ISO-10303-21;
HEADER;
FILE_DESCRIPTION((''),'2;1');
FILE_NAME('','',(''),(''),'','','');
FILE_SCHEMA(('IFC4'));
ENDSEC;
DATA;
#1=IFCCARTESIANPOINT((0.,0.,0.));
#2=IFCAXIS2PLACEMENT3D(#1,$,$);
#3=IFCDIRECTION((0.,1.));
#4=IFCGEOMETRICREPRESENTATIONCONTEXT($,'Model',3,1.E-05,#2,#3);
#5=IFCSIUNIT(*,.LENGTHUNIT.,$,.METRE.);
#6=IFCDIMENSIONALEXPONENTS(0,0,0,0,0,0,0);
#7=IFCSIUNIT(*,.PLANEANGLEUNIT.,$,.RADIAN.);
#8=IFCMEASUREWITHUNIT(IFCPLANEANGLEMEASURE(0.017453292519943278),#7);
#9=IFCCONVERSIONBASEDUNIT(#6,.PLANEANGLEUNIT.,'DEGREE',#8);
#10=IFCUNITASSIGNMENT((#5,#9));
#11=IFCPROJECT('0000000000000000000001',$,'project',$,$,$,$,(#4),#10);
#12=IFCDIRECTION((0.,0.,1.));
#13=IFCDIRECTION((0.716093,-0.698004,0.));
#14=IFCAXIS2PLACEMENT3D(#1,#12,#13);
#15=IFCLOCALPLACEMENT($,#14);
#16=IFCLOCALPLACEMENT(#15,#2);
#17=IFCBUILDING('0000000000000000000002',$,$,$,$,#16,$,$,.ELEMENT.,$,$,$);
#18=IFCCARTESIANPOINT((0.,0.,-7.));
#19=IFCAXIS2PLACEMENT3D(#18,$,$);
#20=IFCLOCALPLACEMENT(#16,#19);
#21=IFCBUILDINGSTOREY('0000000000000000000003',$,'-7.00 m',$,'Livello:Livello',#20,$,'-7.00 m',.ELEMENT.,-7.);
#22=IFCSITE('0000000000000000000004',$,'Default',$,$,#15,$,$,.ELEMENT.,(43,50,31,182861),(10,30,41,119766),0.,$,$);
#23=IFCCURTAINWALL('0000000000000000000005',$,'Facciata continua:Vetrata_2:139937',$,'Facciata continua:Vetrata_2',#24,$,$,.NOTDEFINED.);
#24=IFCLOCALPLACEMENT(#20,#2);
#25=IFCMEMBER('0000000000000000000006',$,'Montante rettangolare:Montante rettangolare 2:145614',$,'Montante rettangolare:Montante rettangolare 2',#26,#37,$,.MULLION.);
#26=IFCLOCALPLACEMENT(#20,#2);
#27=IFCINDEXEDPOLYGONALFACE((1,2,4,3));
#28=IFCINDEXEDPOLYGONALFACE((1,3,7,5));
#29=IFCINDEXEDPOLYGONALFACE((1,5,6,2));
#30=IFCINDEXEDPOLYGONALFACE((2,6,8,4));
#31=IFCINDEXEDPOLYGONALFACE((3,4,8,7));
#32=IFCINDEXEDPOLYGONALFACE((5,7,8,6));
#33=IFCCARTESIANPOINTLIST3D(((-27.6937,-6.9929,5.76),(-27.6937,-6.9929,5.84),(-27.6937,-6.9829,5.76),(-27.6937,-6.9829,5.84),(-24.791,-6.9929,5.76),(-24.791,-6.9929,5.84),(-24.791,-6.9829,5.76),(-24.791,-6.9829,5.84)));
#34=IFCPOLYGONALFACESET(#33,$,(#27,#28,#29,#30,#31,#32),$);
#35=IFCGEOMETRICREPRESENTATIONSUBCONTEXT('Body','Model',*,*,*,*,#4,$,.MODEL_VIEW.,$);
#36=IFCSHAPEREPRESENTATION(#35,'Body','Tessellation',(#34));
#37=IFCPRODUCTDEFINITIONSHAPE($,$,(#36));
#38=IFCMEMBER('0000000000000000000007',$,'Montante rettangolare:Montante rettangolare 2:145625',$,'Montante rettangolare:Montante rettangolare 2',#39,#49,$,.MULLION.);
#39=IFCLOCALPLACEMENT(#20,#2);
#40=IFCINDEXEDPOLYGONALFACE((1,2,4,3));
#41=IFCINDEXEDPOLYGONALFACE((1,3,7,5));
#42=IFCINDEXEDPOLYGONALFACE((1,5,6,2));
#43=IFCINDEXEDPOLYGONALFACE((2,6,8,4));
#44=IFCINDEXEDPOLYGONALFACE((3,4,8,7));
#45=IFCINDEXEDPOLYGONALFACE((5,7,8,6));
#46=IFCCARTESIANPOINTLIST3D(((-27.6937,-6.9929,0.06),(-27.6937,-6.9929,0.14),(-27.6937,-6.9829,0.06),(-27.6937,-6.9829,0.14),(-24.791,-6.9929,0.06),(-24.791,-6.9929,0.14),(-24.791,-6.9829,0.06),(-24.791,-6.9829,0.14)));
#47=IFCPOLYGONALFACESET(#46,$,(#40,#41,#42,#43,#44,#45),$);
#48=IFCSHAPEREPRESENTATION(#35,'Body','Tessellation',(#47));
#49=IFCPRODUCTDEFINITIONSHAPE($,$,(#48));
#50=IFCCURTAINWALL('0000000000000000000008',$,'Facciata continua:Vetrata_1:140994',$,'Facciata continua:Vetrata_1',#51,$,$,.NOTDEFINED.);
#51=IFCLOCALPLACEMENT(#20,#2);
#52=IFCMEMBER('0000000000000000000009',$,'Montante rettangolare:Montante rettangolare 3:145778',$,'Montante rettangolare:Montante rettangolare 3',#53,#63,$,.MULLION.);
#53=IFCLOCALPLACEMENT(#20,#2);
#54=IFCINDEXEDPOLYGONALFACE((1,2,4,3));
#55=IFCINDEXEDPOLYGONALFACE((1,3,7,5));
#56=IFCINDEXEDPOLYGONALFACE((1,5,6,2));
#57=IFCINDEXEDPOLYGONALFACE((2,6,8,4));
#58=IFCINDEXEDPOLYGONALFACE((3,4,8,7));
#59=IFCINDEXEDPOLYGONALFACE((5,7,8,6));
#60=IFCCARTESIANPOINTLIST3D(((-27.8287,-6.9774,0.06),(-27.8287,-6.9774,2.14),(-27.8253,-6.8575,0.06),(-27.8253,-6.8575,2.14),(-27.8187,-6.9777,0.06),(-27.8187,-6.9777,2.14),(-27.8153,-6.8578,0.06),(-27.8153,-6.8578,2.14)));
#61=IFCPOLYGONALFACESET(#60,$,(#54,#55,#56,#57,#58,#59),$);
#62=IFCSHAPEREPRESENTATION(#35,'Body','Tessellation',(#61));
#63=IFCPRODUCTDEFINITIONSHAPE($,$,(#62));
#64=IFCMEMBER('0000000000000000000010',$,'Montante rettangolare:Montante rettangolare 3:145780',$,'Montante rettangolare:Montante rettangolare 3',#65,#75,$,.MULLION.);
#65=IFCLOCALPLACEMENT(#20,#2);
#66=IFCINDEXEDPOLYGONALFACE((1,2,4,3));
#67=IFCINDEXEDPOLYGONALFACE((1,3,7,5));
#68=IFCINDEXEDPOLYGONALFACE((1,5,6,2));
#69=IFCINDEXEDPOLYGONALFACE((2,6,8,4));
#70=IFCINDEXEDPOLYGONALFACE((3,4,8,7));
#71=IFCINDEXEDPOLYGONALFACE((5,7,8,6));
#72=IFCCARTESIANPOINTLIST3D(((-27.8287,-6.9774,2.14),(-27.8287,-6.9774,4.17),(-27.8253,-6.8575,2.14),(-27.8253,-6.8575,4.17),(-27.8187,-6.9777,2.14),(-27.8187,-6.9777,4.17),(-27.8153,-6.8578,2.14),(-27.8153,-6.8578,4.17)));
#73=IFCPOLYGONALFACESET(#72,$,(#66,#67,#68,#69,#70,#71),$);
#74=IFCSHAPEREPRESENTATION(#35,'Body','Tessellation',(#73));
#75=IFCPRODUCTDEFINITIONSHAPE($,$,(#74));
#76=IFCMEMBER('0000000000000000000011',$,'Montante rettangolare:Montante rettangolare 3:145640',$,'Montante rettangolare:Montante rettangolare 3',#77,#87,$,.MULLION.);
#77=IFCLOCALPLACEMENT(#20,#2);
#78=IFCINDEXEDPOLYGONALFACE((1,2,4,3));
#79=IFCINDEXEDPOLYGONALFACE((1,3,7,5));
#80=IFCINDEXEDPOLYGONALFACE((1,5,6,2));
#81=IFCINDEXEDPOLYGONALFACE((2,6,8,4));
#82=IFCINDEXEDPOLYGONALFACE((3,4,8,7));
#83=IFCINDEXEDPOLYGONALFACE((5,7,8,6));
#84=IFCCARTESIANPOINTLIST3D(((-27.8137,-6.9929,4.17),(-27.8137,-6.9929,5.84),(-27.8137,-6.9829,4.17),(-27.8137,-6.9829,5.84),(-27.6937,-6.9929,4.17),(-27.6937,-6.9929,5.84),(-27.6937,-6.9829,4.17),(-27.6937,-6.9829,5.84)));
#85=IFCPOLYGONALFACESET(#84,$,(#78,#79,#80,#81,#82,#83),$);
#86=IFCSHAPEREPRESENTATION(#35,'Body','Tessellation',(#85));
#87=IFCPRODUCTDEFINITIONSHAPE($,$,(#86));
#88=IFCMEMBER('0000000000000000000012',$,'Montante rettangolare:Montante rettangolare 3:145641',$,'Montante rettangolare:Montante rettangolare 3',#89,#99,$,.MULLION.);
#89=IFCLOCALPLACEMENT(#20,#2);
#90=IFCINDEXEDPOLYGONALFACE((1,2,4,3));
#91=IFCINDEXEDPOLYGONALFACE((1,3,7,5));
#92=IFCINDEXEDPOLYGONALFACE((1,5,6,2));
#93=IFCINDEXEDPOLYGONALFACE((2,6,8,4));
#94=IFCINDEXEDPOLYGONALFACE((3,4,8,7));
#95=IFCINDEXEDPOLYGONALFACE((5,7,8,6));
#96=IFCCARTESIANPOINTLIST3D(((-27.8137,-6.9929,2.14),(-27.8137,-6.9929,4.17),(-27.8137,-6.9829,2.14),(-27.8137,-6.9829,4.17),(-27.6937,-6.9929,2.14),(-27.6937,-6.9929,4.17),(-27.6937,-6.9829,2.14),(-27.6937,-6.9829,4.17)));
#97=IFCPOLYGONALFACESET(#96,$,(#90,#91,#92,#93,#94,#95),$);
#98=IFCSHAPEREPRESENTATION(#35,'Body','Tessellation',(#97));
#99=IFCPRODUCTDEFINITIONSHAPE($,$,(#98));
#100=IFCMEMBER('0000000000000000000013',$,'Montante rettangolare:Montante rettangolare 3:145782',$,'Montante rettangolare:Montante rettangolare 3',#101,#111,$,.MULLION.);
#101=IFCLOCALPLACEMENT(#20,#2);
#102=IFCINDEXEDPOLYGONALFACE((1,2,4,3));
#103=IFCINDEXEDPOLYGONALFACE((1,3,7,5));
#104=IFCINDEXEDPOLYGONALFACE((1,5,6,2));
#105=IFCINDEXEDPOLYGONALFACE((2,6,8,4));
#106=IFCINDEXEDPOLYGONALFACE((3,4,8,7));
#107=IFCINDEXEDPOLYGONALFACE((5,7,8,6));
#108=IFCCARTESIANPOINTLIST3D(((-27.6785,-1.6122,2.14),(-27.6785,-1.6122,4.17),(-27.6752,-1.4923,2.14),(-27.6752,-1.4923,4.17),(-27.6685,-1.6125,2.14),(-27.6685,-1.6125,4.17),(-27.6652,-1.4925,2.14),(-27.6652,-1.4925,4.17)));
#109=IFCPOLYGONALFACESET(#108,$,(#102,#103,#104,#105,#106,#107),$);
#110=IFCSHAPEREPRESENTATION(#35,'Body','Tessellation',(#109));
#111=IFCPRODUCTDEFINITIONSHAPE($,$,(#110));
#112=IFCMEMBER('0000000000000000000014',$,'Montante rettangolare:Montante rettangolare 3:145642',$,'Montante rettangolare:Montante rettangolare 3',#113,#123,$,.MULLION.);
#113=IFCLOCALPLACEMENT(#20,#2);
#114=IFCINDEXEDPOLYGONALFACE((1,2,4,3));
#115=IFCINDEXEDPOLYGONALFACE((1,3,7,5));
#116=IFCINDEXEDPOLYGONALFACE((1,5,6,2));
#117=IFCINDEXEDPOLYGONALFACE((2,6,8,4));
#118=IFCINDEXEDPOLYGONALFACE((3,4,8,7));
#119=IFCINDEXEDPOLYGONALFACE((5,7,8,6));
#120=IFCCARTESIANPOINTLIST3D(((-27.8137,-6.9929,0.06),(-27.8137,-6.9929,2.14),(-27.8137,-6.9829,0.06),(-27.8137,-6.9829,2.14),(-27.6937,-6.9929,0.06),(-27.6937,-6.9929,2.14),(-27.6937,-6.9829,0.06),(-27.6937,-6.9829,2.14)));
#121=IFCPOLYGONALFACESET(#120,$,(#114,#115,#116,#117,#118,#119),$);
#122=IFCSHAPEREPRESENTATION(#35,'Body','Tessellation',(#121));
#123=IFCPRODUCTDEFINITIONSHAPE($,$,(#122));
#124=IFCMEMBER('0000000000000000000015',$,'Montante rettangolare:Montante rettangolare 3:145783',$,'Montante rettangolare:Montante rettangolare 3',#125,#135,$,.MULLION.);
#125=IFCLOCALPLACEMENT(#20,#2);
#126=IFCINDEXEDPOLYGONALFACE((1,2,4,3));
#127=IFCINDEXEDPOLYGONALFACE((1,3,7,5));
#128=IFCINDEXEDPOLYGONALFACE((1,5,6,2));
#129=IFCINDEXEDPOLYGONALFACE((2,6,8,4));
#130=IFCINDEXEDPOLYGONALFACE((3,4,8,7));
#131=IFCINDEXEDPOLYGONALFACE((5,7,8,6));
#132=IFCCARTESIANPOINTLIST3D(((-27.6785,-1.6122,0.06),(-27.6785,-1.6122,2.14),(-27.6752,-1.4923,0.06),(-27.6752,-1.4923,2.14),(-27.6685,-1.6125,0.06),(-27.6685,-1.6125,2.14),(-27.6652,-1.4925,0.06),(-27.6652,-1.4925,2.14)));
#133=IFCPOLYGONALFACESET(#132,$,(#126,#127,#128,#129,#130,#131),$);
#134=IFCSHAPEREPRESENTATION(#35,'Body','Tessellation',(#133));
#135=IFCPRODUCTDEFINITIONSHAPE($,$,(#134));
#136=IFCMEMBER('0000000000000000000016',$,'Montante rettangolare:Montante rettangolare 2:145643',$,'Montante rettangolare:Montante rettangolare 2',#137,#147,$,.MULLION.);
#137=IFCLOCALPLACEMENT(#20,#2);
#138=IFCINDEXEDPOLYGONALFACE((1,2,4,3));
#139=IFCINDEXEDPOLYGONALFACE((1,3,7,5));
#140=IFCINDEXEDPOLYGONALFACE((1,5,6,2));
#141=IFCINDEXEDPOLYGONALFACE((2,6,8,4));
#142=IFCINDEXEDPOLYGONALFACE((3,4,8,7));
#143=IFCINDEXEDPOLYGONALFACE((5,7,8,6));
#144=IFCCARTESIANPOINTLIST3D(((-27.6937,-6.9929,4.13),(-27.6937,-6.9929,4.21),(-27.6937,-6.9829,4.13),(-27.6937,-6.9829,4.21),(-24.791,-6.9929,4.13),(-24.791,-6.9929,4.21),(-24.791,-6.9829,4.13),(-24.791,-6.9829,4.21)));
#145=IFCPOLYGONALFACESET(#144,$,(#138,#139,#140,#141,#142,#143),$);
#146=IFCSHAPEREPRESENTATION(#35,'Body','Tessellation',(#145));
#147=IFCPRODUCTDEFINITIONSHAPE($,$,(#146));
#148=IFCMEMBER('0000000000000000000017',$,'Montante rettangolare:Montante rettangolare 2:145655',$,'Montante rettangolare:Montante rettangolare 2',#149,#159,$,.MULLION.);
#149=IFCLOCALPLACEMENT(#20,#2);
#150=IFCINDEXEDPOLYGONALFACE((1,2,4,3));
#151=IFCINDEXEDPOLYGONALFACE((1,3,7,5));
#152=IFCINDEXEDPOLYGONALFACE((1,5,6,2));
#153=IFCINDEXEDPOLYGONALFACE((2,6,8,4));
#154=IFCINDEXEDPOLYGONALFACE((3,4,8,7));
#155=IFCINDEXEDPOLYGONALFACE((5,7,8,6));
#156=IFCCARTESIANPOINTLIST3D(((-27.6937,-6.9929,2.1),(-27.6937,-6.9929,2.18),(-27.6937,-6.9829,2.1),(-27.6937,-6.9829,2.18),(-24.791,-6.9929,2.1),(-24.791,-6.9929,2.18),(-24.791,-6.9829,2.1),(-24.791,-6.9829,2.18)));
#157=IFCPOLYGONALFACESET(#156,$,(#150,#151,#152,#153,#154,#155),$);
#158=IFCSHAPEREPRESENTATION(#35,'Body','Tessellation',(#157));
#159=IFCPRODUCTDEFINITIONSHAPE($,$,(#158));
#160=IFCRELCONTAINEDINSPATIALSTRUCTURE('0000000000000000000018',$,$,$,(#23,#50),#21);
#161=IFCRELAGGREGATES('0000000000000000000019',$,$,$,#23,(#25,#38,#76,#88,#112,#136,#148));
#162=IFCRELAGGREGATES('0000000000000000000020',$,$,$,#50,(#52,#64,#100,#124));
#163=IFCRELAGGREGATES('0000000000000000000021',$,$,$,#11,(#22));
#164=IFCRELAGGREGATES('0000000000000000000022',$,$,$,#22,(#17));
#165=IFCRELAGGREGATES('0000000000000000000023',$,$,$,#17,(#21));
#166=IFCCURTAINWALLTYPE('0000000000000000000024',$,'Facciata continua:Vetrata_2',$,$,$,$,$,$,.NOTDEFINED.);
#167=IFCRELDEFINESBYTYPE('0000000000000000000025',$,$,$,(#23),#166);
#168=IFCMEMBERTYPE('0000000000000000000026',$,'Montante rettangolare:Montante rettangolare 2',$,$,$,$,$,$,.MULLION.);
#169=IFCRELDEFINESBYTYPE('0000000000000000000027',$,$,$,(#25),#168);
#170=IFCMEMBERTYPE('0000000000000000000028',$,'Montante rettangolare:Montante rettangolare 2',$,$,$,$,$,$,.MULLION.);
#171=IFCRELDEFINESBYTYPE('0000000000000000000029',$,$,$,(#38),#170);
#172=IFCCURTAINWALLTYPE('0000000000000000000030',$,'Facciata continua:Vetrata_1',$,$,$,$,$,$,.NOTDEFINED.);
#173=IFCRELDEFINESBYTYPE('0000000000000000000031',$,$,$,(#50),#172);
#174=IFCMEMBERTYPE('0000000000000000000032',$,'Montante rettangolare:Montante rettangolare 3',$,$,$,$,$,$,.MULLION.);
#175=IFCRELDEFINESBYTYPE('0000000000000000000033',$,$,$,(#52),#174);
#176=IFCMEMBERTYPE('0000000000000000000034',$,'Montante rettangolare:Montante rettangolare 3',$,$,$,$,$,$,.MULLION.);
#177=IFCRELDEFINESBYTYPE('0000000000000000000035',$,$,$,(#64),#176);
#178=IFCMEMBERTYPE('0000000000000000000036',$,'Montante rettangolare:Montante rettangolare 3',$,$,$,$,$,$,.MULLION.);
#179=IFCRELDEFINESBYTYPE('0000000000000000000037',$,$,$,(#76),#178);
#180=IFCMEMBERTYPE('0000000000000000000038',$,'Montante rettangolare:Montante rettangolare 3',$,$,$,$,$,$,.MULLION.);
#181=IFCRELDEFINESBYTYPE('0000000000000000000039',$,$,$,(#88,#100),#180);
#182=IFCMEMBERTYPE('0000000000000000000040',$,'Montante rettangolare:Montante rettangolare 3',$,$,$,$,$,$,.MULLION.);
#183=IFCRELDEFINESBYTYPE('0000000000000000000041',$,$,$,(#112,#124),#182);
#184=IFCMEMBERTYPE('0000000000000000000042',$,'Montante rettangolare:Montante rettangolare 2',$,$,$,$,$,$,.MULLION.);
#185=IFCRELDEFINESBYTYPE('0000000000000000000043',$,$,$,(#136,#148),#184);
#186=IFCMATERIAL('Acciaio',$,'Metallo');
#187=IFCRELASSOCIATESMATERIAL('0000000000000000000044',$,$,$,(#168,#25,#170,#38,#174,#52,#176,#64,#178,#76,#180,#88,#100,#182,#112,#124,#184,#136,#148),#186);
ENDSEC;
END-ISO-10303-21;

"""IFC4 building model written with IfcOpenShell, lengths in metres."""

from ifc_helpers import new_model, entity, si_unit, converted_unit, direction, frame, origin, place, context, subcontext, project, spatial, indexed_curve, outline, extrude, source, transform, mapped, material, type_object, type_shapes, element, aggregate, save


model = new_model("IFC4")

# Units and contexts
model_context = context("Model", 3, precision=1e-05, world=origin(), true_north=direction((0.0, 1.0)))
body_context = subcontext(model_context, "Body", "Model", "MODEL_VIEW")
ifc_project = project(units=[si_unit("LENGTHUNIT", "METRE"), converted_unit("PLANEANGLEUNIT", "DEGREE", entity("IfcPlaneAngleMeasure", 0.017453292519943278), si_unit("PLANEANGLEUNIT", "RADIAN"), dimensions=[0, 0, 0, 0, 0, 0, 0])], contexts=[model_context])

# Site, building, storey
site_placement = place(None, frame((0.0, 0.0, 0.0), z_axis=(0.0, 0.0, 1.0), x_axis=(0.716093, -0.698004, 0.0)))
site = spatial("IfcSite", under=ifc_project, at=site_placement, Name="Default", CompositionType="ELEMENT", RefLatitude=(43, 50, 31, 182861), RefLongitude=(10, 30, 41, 119766), RefElevation=0.0)
building_placement = place(site_placement, origin())
building = spatial("IfcBuilding", under=site, at=building_placement, CompositionType="ELEMENT")
storey_placement = place(building_placement, frame((0.0, 0.0, -7.0)))
storey = spatial("IfcBuildingStorey", under=building, at=storey_placement, Name="-7.00 m", ObjectType="Livello:Livello", LongName="-7.00 m", CompositionType="ELEMENT", Elevation=-7.0)

# Curtain walls, members
curtain_wall_type_1 = type_object("IfcCurtainWallType", Name="Facciata continua:Vetrata_2", PredefinedType="NOTDEFINED")
curtain_wall_1_placement = place(storey_placement, frame((0.0, 0.0, 7.0)))
curtain_wall_1 = element("IfcCurtainWall", 1, at=curtain_wall_1_placement, inside=storey, type_object=curtain_wall_type_1, Name="Facciata continua:Vetrata_2:139937", ObjectType="Facciata continua:Vetrata_2", PredefinedType="NOTDEFINED")
ifc_material_1 = material(Name="Acciaio", Category="Metallo")
member_type_1 = type_object("IfcMemberType", Name="Montante rettangolare:Montante rettangolare 2", PredefinedType="MULLION", material=ifc_material_1)
shared_shape_1 = source(origin(), body_context, "Body", "SweptSolid", [
    extrude(outline(indexed_curve([(-0.04, -0.005), (0.04, -0.005), (0.04, 0.005), (-0.04, 0.005), (-0.04, -0.005)], self_intersect=False)), frame((-0.04, 0.01, -2.9027), z_axis=(0.0, 0.0, 1.0), x_axis=(-1.0, 0.0, 0.0)), (0.0, 0.0, 1.0), 2.9027),
])
type_shapes(member_type_1, [shared_shape_1])
member_1_placement = place(curtain_wall_1_placement, frame((-24.791, -6.9779, -1.16), z_axis=(1.0, 0.0, 0.0), x_axis=(0.0, 0.0, 1.0)))
member_1 = element("IfcMember", 2, at=member_1_placement, type_object=member_type_1, material=ifc_material_1, Name="Montante rettangolare:Montante rettangolare 2:145614", ObjectType="Montante rettangolare:Montante rettangolare 2", PredefinedType="MULLION", context=body_context, shape_type="MappedRepresentation", body=[
    mapped(shared_shape_1, transform((0.0, 0.0, 0.0), scale=1.0)),
])
member_type_2 = type_object("IfcMemberType", Name="Montante rettangolare:Montante rettangolare 2", PredefinedType="MULLION", material=ifc_material_1)
shared_shape_2 = source(origin(), body_context, "Body", "SweptSolid", [
    extrude(outline(indexed_curve([(-0.04, -0.005), (0.04, -0.005), (0.04, 0.005), (-0.04, 0.005), (-0.04, -0.005)], self_intersect=False)), frame((-0.04, 0.01, -2.9027), z_axis=(0.0, 0.0, 1.0), x_axis=(-1.0, 0.0, 0.0)), (0.0, 0.0, 1.0), 2.9027),
])
type_shapes(member_type_2, [shared_shape_2])
member_2_placement = place(curtain_wall_1_placement, frame((-27.6937, -6.9779, -6.94), z_axis=(-1.0, 0.0, 0.0), x_axis=(0.0, 0.0, -1.0)))
member_2 = element("IfcMember", 3, at=member_2_placement, type_object=member_type_2, material=ifc_material_1, Name="Montante rettangolare:Montante rettangolare 2:145625", ObjectType="Montante rettangolare:Montante rettangolare 2", PredefinedType="MULLION", context=body_context, shape_type="MappedRepresentation", body=[
    mapped(shared_shape_2, transform((0.0, 0.0, 0.0), scale=1.0)),
])
curtain_wall_type_2 = type_object("IfcCurtainWallType", Name="Facciata continua:Vetrata_1", PredefinedType="NOTDEFINED")
curtain_wall_2_placement = place(storey_placement, frame((0.0, 0.0, 7.0)))
curtain_wall_2 = element("IfcCurtainWall", 4, at=curtain_wall_2_placement, inside=storey, type_object=curtain_wall_type_2, Name="Facciata continua:Vetrata_1:140994", ObjectType="Facciata continua:Vetrata_1", PredefinedType="NOTDEFINED")
member_type_3 = type_object("IfcMemberType", Name="Montante rettangolare:Montante rettangolare 3", PredefinedType="MULLION", material=ifc_material_1)
shared_shape_3 = source(origin(), body_context, "Body", "SweptSolid", [
    extrude(outline(indexed_curve([(-0.06, -0.005), (0.06, -0.005), (0.06, 0.005), (-0.06, 0.005), (-0.06, -0.005)], self_intersect=False)), frame((-0.06, 0.01, -2.08), z_axis=(0.0, 0.0, 1.0), x_axis=(-1.0, 0.0, 0.0)), (0.0, 0.0, 1.0), 2.08),
])
type_shapes(member_type_3, [shared_shape_3])
member_3_placement = place(curtain_wall_2_placement, frame((-27.8137, -6.9779, -6.94), z_axis=(0.0, 0.0, -1.0), x_axis=(-0.02798, -0.999608, 0.0)))
member_3 = element("IfcMember", 5, at=member_3_placement, type_object=member_type_3, material=ifc_material_1, Name="Montante rettangolare:Montante rettangolare 3:145778", ObjectType="Montante rettangolare:Montante rettangolare 3", PredefinedType="MULLION", context=body_context, shape_type="MappedRepresentation", body=[
    mapped(shared_shape_3, transform((0.0, 0.0, 0.0), scale=1.0)),
])
member_type_4 = type_object("IfcMemberType", Name="Montante rettangolare:Montante rettangolare 3", PredefinedType="MULLION", material=ifc_material_1)
shared_shape_4 = source(origin(), body_context, "Body", "SweptSolid", [
    extrude(outline(indexed_curve([(-0.06, -0.005), (0.06, -0.005), (0.06, 0.005), (-0.06, 0.005), (-0.06, -0.005)], self_intersect=False)), frame((-0.06, 0.01, -2.03), z_axis=(0.0, 0.0, 1.0), x_axis=(-1.0, 0.0, 0.0)), (0.0, 0.0, 1.0), 2.03),
])
type_shapes(member_type_4, [shared_shape_4])
member_4_placement = place(curtain_wall_2_placement, frame((-27.8137, -6.9779, -4.86), z_axis=(0.0, 0.0, -1.0), x_axis=(-0.02798, -0.999608, 0.0)))
member_4 = element("IfcMember", 6, at=member_4_placement, type_object=member_type_4, material=ifc_material_1, Name="Montante rettangolare:Montante rettangolare 3:145780", ObjectType="Montante rettangolare:Montante rettangolare 3", PredefinedType="MULLION", context=body_context, shape_type="MappedRepresentation", body=[
    mapped(shared_shape_4, transform((0.0, 0.0, 0.0), scale=1.0)),
])

# Members
member_type_5 = type_object("IfcMemberType", Name="Montante rettangolare:Montante rettangolare 3", PredefinedType="MULLION", material=ifc_material_1)
shared_shape_5 = source(origin(), body_context, "Body", "SweptSolid", [
    extrude(outline(indexed_curve([(-0.06, -0.005), (0.06, -0.005), (0.06, 0.005), (-0.06, 0.005), (-0.06, -0.005)], self_intersect=False)), frame((-0.06, 0.01, -1.67), z_axis=(0.0, 0.0, 1.0), x_axis=(-1.0, 0.0, 0.0)), (0.0, 0.0, 1.0), 1.67),
])
type_shapes(member_type_5, [shared_shape_5])
member_5_placement = place(curtain_wall_1_placement, frame((-27.8137, -6.9779, -1.16), z_axis=(0.0, 0.0, 1.0), x_axis=(-1.0, 0.0, 0.0)))
member_5 = element("IfcMember", 7, at=member_5_placement, type_object=member_type_5, material=ifc_material_1, Name="Montante rettangolare:Montante rettangolare 3:145640", ObjectType="Montante rettangolare:Montante rettangolare 3", PredefinedType="MULLION", context=body_context, shape_type="MappedRepresentation", body=[
    mapped(shared_shape_5, transform((0.0, 0.0, 0.0), scale=1.0)),
])
member_type_6 = type_object("IfcMemberType", Name="Montante rettangolare:Montante rettangolare 3", PredefinedType="MULLION", material=ifc_material_1)
shared_shape_6 = source(origin(), body_context, "Body", "SweptSolid", [
    extrude(outline(indexed_curve([(-0.06, -0.005), (0.06, -0.005), (0.06, 0.005), (-0.06, 0.005), (-0.06, -0.005)], self_intersect=False)), frame((-0.06, 0.01, -2.03), z_axis=(0.0, 0.0, 1.0), x_axis=(-1.0, 0.0, 0.0)), (0.0, 0.0, 1.0), 2.03),
])
type_shapes(member_type_6, [shared_shape_6])
member_6_placement = place(curtain_wall_1_placement, frame((-27.8137, -6.9779, -2.83), z_axis=(0.0, 0.0, 1.0), x_axis=(-1.0, 0.0, 0.0)))
member_6 = element("IfcMember", 8, at=member_6_placement, type_object=member_type_6, material=ifc_material_1, Name="Montante rettangolare:Montante rettangolare 3:145641", ObjectType="Montante rettangolare:Montante rettangolare 3", PredefinedType="MULLION", context=body_context, shape_type="MappedRepresentation", body=[
    mapped(shared_shape_6, transform((0.0, 0.0, 0.0), scale=1.0)),
])
member_7_placement = place(curtain_wall_2_placement, frame((-27.6602, -1.4927, -2.83), z_axis=(0.0, 0.0, 1.0), x_axis=(0.02798, 0.999608, 0.0)))
member_7 = element("IfcMember", 9, at=member_7_placement, type_object=member_type_6, material=ifc_material_1, Name="Montante rettangolare:Montante rettangolare 3:145782", ObjectType="Montante rettangolare:Montante rettangolare 3", PredefinedType="MULLION", context=body_context, shape_type="MappedRepresentation", body=[
    mapped(shared_shape_6, transform((0.0, 0.0, 0.0), scale=1.0)),
])
member_type_7 = type_object("IfcMemberType", Name="Montante rettangolare:Montante rettangolare 3", PredefinedType="MULLION", material=ifc_material_1)
shared_shape_7 = source(origin(), body_context, "Body", "SweptSolid", [
    extrude(outline(indexed_curve([(-0.06, -0.005), (0.06, -0.005), (0.06, 0.005), (-0.06, 0.005), (-0.06, -0.005)], self_intersect=False)), frame((-0.06, 0.01, -2.08), z_axis=(0.0, 0.0, 1.0), x_axis=(-1.0, 0.0, 0.0)), (0.0, 0.0, 1.0), 2.08),
])
type_shapes(member_type_7, [shared_shape_7])
member_8_placement = place(curtain_wall_1_placement, frame((-27.8137, -6.9779, -4.86), z_axis=(0.0, 0.0, 1.0), x_axis=(-1.0, 0.0, 0.0)))
member_8 = element("IfcMember", 10, at=member_8_placement, type_object=member_type_7, material=ifc_material_1, Name="Montante rettangolare:Montante rettangolare 3:145642", ObjectType="Montante rettangolare:Montante rettangolare 3", PredefinedType="MULLION", context=body_context, shape_type="MappedRepresentation", body=[
    mapped(shared_shape_7, transform((0.0, 0.0, 0.0), scale=1.0)),
])
member_9_placement = place(curtain_wall_2_placement, frame((-27.6602, -1.4927, -4.86), z_axis=(0.0, 0.0, 1.0), x_axis=(0.02798, 0.999608, 0.0)))
member_9 = element("IfcMember", 11, at=member_9_placement, type_object=member_type_7, material=ifc_material_1, Name="Montante rettangolare:Montante rettangolare 3:145783", ObjectType="Montante rettangolare:Montante rettangolare 3", PredefinedType="MULLION", context=body_context, shape_type="MappedRepresentation", body=[
    mapped(shared_shape_7, transform((0.0, 0.0, 0.0), scale=1.0)),
])
member_type_8 = type_object("IfcMemberType", Name="Montante rettangolare:Montante rettangolare 2", PredefinedType="MULLION", material=ifc_material_1)
shared_shape_8 = source(origin(), body_context, "Body", "SweptSolid", [
    extrude(outline(indexed_curve([(-0.04, -0.005), (0.04, -0.005), (0.04, 0.005), (-0.04, 0.005), (-0.04, -0.005)], self_intersect=False)), frame((0.0, 0.01, -2.9027), z_axis=(0.0, 0.0, 1.0), x_axis=(-1.0, 0.0, 0.0)), (0.0, 0.0, 1.0), 2.9027),
])
type_shapes(member_type_8, [shared_shape_8])
member_10_placement = place(curtain_wall_1_placement, frame((-24.791, -6.9779, -2.83), z_axis=(1.0, 0.0, 0.0), x_axis=(0.0, 0.0, 1.0)))
member_10 = element("IfcMember", 12, at=member_10_placement, type_object=member_type_8, material=ifc_material_1, Name="Montante rettangolare:Montante rettangolare 2:145643", ObjectType="Montante rettangolare:Montante rettangolare 2", PredefinedType="MULLION", context=body_context, shape_type="MappedRepresentation", body=[
    mapped(shared_shape_8, transform((0.0, 0.0, 0.0), scale=1.0)),
])
member_11_placement = place(curtain_wall_1_placement, frame((-24.791, -6.9779, -4.86), z_axis=(1.0, 0.0, 0.0), x_axis=(0.0, 0.0, 1.0)))
member_11 = element("IfcMember", 13, at=member_11_placement, type_object=member_type_8, material=ifc_material_1, Name="Montante rettangolare:Montante rettangolare 2:145655", ObjectType="Montante rettangolare:Montante rettangolare 2", PredefinedType="MULLION", context=body_context, shape_type="MappedRepresentation", body=[
    mapped(shared_shape_8, transform((0.0, 0.0, 0.0), scale=1.0)),
])
aggregate(curtain_wall_1, [member_1, member_2, member_5, member_6, member_8, member_10, member_11])

aggregate(curtain_wall_2, [member_3, member_4, member_7, member_9])

save(model, "model.ifc")
